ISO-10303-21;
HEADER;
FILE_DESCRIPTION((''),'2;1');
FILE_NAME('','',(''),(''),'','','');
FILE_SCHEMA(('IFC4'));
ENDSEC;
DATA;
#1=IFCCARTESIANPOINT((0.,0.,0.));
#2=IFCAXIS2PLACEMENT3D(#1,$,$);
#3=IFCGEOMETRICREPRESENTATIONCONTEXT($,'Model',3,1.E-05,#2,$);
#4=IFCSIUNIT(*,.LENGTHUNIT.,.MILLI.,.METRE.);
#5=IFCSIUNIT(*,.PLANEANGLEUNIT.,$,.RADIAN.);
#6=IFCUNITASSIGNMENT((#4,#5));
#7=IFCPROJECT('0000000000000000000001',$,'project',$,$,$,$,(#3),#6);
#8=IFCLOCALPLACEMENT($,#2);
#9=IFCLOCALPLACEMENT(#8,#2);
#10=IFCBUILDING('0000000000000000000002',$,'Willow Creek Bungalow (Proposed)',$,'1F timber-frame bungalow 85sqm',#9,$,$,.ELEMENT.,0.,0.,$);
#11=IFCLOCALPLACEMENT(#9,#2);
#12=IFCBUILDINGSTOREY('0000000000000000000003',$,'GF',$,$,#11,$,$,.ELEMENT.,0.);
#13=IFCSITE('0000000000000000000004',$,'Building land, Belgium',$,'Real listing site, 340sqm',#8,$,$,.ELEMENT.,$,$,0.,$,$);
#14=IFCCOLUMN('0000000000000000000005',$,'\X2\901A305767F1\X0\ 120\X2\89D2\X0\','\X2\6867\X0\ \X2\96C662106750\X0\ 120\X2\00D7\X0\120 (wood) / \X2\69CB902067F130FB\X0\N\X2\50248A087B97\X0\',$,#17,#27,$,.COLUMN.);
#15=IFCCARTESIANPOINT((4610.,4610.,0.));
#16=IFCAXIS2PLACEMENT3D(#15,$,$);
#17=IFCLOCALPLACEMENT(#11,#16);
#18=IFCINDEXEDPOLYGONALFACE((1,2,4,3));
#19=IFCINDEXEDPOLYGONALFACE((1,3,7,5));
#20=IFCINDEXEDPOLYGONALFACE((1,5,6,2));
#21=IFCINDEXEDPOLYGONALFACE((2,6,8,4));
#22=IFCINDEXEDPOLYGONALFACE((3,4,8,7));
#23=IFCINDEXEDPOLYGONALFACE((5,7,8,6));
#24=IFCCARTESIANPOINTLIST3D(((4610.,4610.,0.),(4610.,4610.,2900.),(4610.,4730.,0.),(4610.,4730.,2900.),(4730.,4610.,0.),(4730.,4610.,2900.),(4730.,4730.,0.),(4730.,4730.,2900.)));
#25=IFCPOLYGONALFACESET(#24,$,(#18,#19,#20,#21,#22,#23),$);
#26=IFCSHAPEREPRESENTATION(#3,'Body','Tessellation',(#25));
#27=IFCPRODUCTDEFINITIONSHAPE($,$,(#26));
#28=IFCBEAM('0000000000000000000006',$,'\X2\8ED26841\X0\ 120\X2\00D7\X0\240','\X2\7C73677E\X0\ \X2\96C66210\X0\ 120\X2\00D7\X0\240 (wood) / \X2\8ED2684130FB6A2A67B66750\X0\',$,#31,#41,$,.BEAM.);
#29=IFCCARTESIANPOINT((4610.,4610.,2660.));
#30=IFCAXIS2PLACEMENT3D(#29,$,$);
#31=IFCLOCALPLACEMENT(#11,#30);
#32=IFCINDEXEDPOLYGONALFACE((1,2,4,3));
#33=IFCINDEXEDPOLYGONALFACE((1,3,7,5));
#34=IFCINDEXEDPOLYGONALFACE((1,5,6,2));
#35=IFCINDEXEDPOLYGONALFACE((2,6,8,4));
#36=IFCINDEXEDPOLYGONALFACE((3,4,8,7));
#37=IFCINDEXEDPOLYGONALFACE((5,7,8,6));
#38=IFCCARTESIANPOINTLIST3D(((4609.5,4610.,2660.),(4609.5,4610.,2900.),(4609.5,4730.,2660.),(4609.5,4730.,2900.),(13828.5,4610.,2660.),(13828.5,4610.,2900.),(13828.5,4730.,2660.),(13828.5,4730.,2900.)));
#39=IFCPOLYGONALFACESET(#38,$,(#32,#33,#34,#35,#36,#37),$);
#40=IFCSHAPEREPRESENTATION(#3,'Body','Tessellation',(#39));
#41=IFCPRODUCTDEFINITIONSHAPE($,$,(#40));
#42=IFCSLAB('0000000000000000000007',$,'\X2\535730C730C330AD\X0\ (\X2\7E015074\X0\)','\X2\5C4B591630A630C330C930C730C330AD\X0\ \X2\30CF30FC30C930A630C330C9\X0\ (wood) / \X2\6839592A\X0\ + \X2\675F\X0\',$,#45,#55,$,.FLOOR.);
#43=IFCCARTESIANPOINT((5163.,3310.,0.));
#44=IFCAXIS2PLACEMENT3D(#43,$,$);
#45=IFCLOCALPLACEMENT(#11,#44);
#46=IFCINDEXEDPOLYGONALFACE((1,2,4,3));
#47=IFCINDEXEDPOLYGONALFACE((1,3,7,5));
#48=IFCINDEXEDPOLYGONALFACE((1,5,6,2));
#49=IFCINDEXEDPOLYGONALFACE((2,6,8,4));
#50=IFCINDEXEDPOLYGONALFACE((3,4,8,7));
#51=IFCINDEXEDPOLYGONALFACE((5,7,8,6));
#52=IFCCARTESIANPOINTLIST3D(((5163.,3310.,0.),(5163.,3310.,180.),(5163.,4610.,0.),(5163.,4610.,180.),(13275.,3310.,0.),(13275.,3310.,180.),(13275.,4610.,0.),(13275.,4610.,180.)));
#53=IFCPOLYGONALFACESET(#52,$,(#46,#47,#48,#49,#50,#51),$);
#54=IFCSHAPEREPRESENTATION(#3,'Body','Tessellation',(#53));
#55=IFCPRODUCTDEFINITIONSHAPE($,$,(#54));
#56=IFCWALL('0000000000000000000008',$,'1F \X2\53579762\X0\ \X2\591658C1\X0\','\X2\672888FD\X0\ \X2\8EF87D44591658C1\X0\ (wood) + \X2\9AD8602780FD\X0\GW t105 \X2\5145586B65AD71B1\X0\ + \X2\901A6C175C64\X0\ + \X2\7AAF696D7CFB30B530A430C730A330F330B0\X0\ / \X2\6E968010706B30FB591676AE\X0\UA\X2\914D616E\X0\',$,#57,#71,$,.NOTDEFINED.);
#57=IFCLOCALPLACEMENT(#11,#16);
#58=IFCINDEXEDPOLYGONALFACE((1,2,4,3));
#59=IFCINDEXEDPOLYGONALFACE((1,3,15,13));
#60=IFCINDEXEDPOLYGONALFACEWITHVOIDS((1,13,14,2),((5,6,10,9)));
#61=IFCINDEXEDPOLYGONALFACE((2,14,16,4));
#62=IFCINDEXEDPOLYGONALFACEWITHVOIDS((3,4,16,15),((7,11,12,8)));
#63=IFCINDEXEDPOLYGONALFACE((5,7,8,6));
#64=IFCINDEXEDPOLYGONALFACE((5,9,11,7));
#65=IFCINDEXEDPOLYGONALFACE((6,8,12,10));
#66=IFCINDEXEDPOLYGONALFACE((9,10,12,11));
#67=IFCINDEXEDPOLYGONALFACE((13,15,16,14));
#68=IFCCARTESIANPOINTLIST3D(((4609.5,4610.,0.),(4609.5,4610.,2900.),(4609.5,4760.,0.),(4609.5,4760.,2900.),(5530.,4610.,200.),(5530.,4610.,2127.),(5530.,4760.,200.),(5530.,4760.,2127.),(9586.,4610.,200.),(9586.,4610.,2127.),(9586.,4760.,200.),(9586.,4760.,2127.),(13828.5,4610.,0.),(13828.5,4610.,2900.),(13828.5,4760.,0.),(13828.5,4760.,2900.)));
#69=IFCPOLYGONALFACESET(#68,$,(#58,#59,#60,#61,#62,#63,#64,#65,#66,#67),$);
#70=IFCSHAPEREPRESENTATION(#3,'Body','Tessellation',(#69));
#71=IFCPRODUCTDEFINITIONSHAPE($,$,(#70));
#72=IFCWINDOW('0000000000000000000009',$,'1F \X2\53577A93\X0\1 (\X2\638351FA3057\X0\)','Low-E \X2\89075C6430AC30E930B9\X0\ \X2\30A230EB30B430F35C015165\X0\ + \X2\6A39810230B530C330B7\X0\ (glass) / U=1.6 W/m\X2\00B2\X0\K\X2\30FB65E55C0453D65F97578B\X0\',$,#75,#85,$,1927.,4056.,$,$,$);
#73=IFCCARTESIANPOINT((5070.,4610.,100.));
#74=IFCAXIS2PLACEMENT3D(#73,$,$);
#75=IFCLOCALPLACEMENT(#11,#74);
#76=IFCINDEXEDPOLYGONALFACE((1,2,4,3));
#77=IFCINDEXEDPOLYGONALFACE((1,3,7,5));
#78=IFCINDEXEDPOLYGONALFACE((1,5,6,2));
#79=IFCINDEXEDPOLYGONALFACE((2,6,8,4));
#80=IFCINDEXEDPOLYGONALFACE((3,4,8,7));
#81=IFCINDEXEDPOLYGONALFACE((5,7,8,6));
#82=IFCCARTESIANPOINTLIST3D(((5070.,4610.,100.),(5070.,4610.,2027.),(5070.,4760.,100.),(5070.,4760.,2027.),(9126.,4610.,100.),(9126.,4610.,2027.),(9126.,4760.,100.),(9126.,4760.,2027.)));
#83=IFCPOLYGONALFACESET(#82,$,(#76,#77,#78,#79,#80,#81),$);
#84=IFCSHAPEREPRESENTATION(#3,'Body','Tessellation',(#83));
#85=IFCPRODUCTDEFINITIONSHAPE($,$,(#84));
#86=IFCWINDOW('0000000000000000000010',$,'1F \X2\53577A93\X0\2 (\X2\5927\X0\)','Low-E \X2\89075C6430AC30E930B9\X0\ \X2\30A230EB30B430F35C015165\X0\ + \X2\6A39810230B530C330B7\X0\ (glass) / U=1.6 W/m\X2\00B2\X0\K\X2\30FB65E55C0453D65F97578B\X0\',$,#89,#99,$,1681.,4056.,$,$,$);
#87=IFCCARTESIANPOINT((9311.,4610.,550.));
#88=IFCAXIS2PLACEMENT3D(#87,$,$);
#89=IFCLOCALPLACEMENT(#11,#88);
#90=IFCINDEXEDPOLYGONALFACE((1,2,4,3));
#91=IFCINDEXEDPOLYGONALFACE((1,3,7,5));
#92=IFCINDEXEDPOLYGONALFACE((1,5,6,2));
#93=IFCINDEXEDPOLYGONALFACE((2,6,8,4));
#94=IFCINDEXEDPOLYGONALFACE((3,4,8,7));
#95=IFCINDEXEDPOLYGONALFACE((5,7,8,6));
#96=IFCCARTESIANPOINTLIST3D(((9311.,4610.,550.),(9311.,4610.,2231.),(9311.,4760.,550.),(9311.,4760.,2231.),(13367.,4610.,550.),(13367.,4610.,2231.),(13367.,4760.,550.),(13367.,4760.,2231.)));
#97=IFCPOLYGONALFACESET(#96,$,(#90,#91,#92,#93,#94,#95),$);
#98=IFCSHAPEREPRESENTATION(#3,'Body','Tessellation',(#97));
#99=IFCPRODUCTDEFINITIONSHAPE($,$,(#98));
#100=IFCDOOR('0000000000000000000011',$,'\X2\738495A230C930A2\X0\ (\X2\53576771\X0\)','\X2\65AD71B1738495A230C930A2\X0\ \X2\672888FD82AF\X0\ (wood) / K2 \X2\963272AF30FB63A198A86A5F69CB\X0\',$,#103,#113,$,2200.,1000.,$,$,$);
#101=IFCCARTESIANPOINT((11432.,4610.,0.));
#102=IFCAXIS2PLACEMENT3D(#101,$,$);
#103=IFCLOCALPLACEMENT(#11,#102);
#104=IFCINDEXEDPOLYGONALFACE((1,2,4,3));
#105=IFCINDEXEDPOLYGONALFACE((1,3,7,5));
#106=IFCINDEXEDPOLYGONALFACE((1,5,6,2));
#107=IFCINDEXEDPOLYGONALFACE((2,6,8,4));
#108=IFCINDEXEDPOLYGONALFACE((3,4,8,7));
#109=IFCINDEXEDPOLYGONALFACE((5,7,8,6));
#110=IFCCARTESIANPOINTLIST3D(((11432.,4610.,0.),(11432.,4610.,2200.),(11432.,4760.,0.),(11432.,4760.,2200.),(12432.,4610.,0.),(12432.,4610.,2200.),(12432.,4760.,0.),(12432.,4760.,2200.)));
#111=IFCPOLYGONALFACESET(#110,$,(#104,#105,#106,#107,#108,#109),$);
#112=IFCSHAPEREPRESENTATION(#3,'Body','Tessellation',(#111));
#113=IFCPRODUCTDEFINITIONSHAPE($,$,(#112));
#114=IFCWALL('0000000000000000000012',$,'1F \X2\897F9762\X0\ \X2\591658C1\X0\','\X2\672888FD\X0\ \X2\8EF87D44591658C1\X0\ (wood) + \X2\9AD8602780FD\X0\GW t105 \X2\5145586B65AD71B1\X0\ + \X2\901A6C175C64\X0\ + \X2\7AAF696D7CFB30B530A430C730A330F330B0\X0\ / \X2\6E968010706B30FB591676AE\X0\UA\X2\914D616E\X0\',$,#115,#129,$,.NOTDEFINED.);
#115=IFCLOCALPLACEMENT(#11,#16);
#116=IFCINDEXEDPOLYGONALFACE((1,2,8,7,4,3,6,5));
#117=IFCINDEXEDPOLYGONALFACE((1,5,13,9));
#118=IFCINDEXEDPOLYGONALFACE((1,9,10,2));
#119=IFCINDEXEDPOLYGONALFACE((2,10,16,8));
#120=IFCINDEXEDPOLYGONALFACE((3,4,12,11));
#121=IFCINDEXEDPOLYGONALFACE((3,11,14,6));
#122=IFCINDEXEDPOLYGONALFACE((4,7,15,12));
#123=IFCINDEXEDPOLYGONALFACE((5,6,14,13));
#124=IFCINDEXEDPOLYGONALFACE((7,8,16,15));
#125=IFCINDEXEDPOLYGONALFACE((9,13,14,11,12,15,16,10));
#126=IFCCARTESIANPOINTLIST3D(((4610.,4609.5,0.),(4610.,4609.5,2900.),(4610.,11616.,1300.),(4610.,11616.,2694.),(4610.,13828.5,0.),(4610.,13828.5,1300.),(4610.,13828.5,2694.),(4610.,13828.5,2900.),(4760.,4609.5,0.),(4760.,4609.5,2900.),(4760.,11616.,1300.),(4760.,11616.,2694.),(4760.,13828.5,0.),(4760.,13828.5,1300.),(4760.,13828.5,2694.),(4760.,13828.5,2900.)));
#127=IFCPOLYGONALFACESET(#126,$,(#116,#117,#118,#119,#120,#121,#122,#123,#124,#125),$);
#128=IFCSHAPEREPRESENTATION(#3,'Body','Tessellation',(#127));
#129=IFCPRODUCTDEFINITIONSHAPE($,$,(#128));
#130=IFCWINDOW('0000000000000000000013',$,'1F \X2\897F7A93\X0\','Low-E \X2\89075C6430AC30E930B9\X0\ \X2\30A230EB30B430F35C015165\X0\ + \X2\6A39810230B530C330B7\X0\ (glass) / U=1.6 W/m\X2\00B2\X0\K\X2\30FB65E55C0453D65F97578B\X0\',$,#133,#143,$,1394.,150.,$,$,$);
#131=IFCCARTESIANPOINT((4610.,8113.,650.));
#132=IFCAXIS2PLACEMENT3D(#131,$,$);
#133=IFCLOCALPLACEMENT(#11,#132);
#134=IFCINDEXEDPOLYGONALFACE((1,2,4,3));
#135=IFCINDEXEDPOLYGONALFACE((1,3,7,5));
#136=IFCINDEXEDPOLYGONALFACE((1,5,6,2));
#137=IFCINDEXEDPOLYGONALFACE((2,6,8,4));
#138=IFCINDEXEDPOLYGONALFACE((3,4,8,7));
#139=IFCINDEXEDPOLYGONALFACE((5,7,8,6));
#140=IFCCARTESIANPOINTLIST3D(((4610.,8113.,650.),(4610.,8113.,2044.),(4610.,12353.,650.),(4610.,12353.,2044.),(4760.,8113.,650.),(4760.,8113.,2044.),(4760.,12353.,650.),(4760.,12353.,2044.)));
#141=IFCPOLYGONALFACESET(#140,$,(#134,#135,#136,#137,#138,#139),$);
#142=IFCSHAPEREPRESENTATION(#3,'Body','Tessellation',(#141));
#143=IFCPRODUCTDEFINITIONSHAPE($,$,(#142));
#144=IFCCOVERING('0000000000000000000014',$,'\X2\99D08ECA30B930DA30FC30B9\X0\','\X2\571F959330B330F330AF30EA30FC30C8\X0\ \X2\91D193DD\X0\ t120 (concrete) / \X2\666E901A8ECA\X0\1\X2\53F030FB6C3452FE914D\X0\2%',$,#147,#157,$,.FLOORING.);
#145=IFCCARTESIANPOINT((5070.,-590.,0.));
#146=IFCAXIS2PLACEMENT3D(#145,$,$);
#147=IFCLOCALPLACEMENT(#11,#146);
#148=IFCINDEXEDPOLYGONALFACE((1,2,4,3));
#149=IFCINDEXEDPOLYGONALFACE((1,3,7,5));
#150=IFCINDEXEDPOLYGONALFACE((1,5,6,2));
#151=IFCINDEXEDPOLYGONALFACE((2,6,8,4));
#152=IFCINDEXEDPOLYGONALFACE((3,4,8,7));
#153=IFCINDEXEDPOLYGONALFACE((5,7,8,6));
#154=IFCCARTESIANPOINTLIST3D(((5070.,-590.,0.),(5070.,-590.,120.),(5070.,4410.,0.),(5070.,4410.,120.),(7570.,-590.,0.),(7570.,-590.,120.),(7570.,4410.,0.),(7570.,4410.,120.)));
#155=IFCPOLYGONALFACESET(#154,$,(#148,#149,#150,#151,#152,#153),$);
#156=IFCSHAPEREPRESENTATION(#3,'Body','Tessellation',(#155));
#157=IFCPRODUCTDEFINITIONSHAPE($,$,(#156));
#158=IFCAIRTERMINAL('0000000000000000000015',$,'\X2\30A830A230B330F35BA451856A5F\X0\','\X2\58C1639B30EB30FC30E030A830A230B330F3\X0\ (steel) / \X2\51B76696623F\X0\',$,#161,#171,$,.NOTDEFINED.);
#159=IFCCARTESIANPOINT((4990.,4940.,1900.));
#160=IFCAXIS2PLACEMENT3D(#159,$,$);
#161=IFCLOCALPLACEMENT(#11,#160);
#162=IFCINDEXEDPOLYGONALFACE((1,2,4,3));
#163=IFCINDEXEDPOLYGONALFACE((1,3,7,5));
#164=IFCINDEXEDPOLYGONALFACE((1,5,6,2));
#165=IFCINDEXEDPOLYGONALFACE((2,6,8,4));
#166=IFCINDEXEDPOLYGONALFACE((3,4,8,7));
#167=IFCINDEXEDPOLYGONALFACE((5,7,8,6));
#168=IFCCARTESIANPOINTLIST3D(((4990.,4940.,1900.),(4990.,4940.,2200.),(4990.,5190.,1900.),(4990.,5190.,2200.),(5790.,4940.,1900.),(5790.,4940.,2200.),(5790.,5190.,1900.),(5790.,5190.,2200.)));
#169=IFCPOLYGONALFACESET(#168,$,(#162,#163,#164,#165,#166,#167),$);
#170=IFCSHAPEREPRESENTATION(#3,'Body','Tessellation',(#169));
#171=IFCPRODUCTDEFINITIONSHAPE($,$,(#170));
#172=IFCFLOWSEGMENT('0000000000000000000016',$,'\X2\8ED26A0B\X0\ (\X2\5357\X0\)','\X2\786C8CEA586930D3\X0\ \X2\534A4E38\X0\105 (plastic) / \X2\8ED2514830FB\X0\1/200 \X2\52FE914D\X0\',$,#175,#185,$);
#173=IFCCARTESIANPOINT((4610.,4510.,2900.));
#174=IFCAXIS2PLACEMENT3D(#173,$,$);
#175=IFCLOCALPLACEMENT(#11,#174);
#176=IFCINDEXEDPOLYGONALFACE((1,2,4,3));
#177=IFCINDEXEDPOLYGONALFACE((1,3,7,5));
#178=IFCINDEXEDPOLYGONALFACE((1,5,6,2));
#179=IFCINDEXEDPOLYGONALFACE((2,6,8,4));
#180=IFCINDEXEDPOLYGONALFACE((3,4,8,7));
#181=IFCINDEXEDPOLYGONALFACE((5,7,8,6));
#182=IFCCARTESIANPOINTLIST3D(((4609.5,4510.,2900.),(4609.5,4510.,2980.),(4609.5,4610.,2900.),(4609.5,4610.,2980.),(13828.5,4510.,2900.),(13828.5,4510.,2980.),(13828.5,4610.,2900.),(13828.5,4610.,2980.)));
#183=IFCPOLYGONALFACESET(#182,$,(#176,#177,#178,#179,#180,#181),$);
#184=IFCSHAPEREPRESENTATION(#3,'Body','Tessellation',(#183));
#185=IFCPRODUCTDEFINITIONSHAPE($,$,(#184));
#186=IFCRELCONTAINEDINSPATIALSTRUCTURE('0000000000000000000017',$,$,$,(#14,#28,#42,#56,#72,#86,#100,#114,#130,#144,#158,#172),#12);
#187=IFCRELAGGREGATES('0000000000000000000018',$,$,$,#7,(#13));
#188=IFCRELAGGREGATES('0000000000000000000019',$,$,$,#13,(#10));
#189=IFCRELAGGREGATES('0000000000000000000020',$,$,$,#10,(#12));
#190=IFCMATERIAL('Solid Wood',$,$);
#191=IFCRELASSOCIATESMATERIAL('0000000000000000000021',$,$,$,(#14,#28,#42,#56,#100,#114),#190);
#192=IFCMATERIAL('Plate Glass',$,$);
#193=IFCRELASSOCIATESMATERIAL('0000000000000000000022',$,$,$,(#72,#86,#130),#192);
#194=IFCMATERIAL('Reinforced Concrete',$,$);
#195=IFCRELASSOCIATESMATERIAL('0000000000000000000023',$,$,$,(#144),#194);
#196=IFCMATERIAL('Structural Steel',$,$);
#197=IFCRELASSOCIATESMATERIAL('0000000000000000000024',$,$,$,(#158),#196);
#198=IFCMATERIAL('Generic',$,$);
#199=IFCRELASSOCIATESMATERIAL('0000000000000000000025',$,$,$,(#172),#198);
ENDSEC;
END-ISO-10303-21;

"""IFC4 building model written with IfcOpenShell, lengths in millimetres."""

from ifc_helpers import new_model, si_unit, frame, frame_2d, origin, place, context, project, spatial, rectangle, extrude, material, element, fill, save


model = new_model("IFC4")

# Units and contexts
model_context = context("Model", 3, precision=1e-05, world=origin())
ifc_project = project(units=[si_unit("LENGTHUNIT", "METRE", prefix="MILLI"), si_unit("PLANEANGLEUNIT", "RADIAN")], contexts=[model_context])

# Site, building, storey
site_placement = place(None, origin())
site = spatial("IfcSite", under=ifc_project, at=site_placement, Name="Building land, Belgium", ObjectType="Real listing site, 340sqm", CompositionType="ELEMENT", RefElevation=0.0)
building_placement = place(site_placement, origin())
building = spatial("IfcBuilding", under=site, at=building_placement, Name="Willow Creek Bungalow (Proposed)", ObjectType="1F timber-frame bungalow 85sqm", CompositionType="ELEMENT", ElevationOfRefHeight=0.0, ElevationOfTerrain=0.0)
storey_placement = place(building_placement, origin())
storey = spatial("IfcBuildingStorey", under=building, at=storey_placement, Name="GF", CompositionType="ELEMENT", Elevation=0.0)

# Column
ifc_material_1 = material(Name="Solid Wood")
column_1_placement = place(storey_placement, frame((4610.0, 4610.0, 0.0)))
element("IfcColumn", 1, at=column_1_placement, inside=storey, material=ifc_material_1, Name="通し柱 120角", Description="桧 集成材 120×120 (wood) / 構造柱・N値計算", PredefinedType="COLUMN", context=model_context, shape_type="SweptSolid", body=[
    extrude(rectangle(XDim=120.0, YDim=120.0, at=frame_2d((60.0, 60.0))), frame((4610.0, 4610.0, 0.0)), (0.0, 0.0, 1.0), 2900.0),
])

# Beam
beam_1_placement = place(storey_placement, frame((4610.0, 4610.0, 2660.0)))
element("IfcBeam", 2, at=beam_1_placement, inside=storey, material=ifc_material_1, Name="軒桁 120×240", Description="米松 集成 120×240 (wood) / 軒桁・横架材", PredefinedType="BEAM", context=model_context, shape_type="SweptSolid", body=[
    extrude(rectangle(XDim=9219.0, YDim=120.0, at=frame_2d((4609.0, 60.0))), frame((4610.0, 4610.0, 2660.0)), (0.0, 0.0, 1.0), 240.0),
])

# Slab
ifc_material_2 = material(Name="Reinforced Concrete")
slab_1_placement = place(storey_placement, frame((5163.0, 3310.0, 0.0)))
element("IfcSlab", 3, at=slab_1_placement, inside=storey, material=ifc_material_1, Name="南デッキ (縁側)", Description="屋外ウッドデッキ ハードウッド (wood) / 根太 + 束", PredefinedType="FLOOR", context=model_context, shape_type="SweptSolid", body=[
    extrude(rectangle(XDim=8112.0, YDim=1300.0, at=frame_2d((4056.0, 650.0))), frame((5163.0, 3310.0, 0.0)), (0.0, 0.0, 1.0), 180.0),
])

# Wall, openings, windows, door
wall_1_placement = place(storey_placement, frame((4610.0, 4610.0, 0.0)))
wall_1 = element("IfcWall", 4, at=wall_1_placement, inside=storey, material=ifc_material_1, Name="1F 南面 外壁", Description="木製 軸組外壁 (wood) + 高性能GW t105 充填断熱 + 通気層 + 窯業系サイディング / 準耐火・外皮UA配慮", PredefinedType="NOTDEFINED", context=model_context, shape_type="SweptSolid", body=[
    extrude(rectangle(XDim=9219.0, YDim=150.0, at=frame_2d((4609.0, 75.0))), frame((4610.0, 4610.0, 0.0)), (0.0, 0.0, 1.0), 2900.0),
])
opening_1_placement = place(storey_placement, frame((5070.0, 4610.0, 100.0)))
opening_1 = element("IfcOpeningElement", 5, at=opening_1_placement, cuts=wall_1, PredefinedType="NOTDEFINED", context=model_context, shape_type="SweptSolid", body=[
    extrude(rectangle(XDim=4056.0, YDim=150.0, at=frame_2d((2028.0, 75.0))), frame((5070.0, 4610.0, 100.0)), (0.0, 0.0, 1.0), 1927.0),
])
opening_2_placement = place(storey_placement, frame((9311.0, 4610.0, 550.0)))
opening_2 = element("IfcOpeningElement", 6, at=opening_2_placement, cuts=wall_1, PredefinedType="NOTDEFINED", context=model_context, shape_type="SweptSolid", body=[
    extrude(rectangle(XDim=4056.0, YDim=150.0, at=frame_2d((2028.0, 75.0))), frame((9311.0, 4610.0, 550.0)), (0.0, 0.0, 1.0), 1681.0),
])
opening_3_placement = place(storey_placement, frame((11432.0, 4610.0, 0.0)))
opening_3 = element("IfcOpeningElement", 7, at=opening_3_placement, cuts=wall_1, PredefinedType="NOTDEFINED", context=model_context, shape_type="SweptSolid", body=[
    extrude(rectangle(XDim=1000.0, YDim=150.0, at=frame_2d((500.0, 75.0))), frame((11432.0, 4610.0, 0.0)), (0.0, 0.0, 1.0), 2200.0),
])
ifc_material_3 = material(Name="Plate Glass")
window_1_placement = place(storey_placement, frame((5070.0, 4610.0, 100.0)))
window_1 = element("IfcWindow", 8, at=window_1_placement, inside=storey, material=ifc_material_3, Name="1F 南窓1 (掃出し)", Description="Low-E 複層ガラス アルゴン封入 + 樹脂サッシ (glass) / U=1.6 W/m²K・日射取得型", OverallHeight=1927.0, OverallWidth=4056.0, context=model_context, shape_type="SweptSolid", body=[
    extrude(rectangle(XDim=4056.0, YDim=150.0, at=frame_2d((2028.0, 75.0))), frame((5070.0, 4610.0, 100.0)), (0.0, 0.0, 1.0), 1927.0),
])
fill(opening_1, window_1)
window_2_placement = place(storey_placement, frame((9311.0, 4610.0, 550.0)))
window_2 = element("IfcWindow", 9, at=window_2_placement, inside=storey, material=ifc_material_3, Name="1F 南窓2 (大)", Description="Low-E 複層ガラス アルゴン封入 + 樹脂サッシ (glass) / U=1.6 W/m²K・日射取得型", OverallHeight=1681.0, OverallWidth=4056.0, context=model_context, shape_type="SweptSolid", body=[
    extrude(rectangle(XDim=4056.0, YDim=150.0, at=frame_2d((2028.0, 75.0))), frame((9311.0, 4610.0, 550.0)), (0.0, 0.0, 1.0), 1681.0),
])
fill(opening_2, window_2)
door_placement = place(storey_placement, frame((11432.0, 4610.0, 0.0)))
door = element("IfcDoor", 10, at=door_placement, inside=storey, material=ifc_material_1, Name="玄関ドア (南東)", Description="断熱玄関ドア 木製芯 (wood) / K2 防犯・採風機構", OverallHeight=2200.0, OverallWidth=1000.0, context=model_context, shape_type="SweptSolid", body=[
    extrude(rectangle(XDim=1000.0, YDim=150.0, at=frame_2d((500.0, 75.0))), frame((11432.0, 4610.0, 0.0)), (0.0, 0.0, 1.0), 2200.0),
])
fill(opening_3, door)

# Wall, opening, window
wall_2_placement = place(storey_placement, frame((4610.0, 4610.0, 0.0)))
wall_2 = element("IfcWall", 11, at=wall_2_placement, inside=storey, material=ifc_material_1, Name="1F 西面 外壁", Description="木製 軸組外壁 (wood) + 高性能GW t105 充填断熱 + 通気層 + 窯業系サイディング / 準耐火・外皮UA配慮", PredefinedType="NOTDEFINED", context=model_context, shape_type="SweptSolid", body=[
    extrude(rectangle(XDim=150.0, YDim=9219.0, at=frame_2d((75.0, 4609.0))), frame((4610.0, 4610.0, 0.0)), (0.0, 0.0, 1.0), 2900.0),
])
opening_4_placement = place(storey_placement, frame((4610.0, 8113.0, 650.0)))
opening_4 = element("IfcOpeningElement", 12, at=opening_4_placement, cuts=wall_2, PredefinedType="NOTDEFINED", context=model_context, shape_type="SweptSolid", body=[
    extrude(rectangle(XDim=150.0, YDim=4240.0, at=frame_2d((75.0, 2120.0))), frame((4610.0, 8113.0, 650.0)), (0.0, 0.0, 1.0), 1394.0),
])
window_3_placement = place(storey_placement, frame((4610.0, 8113.0, 650.0)))
window_3 = element("IfcWindow", 13, at=window_3_placement, inside=storey, material=ifc_material_3, Name="1F 西窓", Description="Low-E 複層ガラス アルゴン封入 + 樹脂サッシ (glass) / U=1.6 W/m²K・日射取得型", OverallHeight=1394.0, OverallWidth=150.0, context=model_context, shape_type="SweptSolid", body=[
    extrude(rectangle(XDim=150.0, YDim=4240.0, at=frame_2d((75.0, 2120.0))), frame((4610.0, 8113.0, 650.0)), (0.0, 0.0, 1.0), 1394.0),
])
fill(opening_4, window_3)

# Shared definitions
ifc_material_4 = material(Name="Structural Steel")

# Covering
ifc_material_5 = material(Name="Generic")
covering_1_placement = place(storey_placement, frame((5070.0, -590.0, 0.0)))
element("IfcCovering", 14, at=covering_1_placement, inside=storey, material=ifc_material_2, Name="駐車スペース", Description="土間コンクリート 金鏝 t120 (concrete) / 普通車1台・水勾配2%", PredefinedType="FLOORING", context=model_context, shape_type="SweptSolid", body=[
    extrude(rectangle(XDim=2500.0, YDim=5000.0, at=frame_2d((1250.0, 2500.0))), frame((5070.0, -590.0, 0.0)), (0.0, 0.0, 1.0), 120.0),
])

# Air terminal
air_terminal_placement = place(storey_placement, frame((4990.0, 4940.0, 1900.0)))
element("IfcAirTerminal", 15, at=air_terminal_placement, inside=storey, material=ifc_material_4, Name="エアコン室内機", Description="壁掛ルームエアコン (steel) / 冷暖房", PredefinedType="NOTDEFINED", context=model_context, shape_type="SweptSolid", body=[
    extrude(rectangle(XDim=800.0, YDim=250.0, at=frame_2d((400.0, 125.0))), frame((4990.0, 4940.0, 1900.0)), (0.0, 0.0, 1.0), 300.0),
])

# Flow segment
flow_segment_1_placement = place(storey_placement, frame((4610.0, 4510.0, 2900.0)))
element("IfcFlowSegment", 16, at=flow_segment_1_placement, inside=storey, material=ifc_material_5, Name="軒樋 (南)", Description="硬質塩ビ 半丸105 (plastic) / 軒先・1/200 勾配", context=model_context, shape_type="SweptSolid", body=[
    extrude(rectangle(XDim=9219.0, YDim=100.0, at=frame_2d((4609.0, 50.0))), frame((4610.0, 4510.0, 2900.0)), (0.0, 0.0, 1.0), 80.0),
])

save(model, "model.ifc")
